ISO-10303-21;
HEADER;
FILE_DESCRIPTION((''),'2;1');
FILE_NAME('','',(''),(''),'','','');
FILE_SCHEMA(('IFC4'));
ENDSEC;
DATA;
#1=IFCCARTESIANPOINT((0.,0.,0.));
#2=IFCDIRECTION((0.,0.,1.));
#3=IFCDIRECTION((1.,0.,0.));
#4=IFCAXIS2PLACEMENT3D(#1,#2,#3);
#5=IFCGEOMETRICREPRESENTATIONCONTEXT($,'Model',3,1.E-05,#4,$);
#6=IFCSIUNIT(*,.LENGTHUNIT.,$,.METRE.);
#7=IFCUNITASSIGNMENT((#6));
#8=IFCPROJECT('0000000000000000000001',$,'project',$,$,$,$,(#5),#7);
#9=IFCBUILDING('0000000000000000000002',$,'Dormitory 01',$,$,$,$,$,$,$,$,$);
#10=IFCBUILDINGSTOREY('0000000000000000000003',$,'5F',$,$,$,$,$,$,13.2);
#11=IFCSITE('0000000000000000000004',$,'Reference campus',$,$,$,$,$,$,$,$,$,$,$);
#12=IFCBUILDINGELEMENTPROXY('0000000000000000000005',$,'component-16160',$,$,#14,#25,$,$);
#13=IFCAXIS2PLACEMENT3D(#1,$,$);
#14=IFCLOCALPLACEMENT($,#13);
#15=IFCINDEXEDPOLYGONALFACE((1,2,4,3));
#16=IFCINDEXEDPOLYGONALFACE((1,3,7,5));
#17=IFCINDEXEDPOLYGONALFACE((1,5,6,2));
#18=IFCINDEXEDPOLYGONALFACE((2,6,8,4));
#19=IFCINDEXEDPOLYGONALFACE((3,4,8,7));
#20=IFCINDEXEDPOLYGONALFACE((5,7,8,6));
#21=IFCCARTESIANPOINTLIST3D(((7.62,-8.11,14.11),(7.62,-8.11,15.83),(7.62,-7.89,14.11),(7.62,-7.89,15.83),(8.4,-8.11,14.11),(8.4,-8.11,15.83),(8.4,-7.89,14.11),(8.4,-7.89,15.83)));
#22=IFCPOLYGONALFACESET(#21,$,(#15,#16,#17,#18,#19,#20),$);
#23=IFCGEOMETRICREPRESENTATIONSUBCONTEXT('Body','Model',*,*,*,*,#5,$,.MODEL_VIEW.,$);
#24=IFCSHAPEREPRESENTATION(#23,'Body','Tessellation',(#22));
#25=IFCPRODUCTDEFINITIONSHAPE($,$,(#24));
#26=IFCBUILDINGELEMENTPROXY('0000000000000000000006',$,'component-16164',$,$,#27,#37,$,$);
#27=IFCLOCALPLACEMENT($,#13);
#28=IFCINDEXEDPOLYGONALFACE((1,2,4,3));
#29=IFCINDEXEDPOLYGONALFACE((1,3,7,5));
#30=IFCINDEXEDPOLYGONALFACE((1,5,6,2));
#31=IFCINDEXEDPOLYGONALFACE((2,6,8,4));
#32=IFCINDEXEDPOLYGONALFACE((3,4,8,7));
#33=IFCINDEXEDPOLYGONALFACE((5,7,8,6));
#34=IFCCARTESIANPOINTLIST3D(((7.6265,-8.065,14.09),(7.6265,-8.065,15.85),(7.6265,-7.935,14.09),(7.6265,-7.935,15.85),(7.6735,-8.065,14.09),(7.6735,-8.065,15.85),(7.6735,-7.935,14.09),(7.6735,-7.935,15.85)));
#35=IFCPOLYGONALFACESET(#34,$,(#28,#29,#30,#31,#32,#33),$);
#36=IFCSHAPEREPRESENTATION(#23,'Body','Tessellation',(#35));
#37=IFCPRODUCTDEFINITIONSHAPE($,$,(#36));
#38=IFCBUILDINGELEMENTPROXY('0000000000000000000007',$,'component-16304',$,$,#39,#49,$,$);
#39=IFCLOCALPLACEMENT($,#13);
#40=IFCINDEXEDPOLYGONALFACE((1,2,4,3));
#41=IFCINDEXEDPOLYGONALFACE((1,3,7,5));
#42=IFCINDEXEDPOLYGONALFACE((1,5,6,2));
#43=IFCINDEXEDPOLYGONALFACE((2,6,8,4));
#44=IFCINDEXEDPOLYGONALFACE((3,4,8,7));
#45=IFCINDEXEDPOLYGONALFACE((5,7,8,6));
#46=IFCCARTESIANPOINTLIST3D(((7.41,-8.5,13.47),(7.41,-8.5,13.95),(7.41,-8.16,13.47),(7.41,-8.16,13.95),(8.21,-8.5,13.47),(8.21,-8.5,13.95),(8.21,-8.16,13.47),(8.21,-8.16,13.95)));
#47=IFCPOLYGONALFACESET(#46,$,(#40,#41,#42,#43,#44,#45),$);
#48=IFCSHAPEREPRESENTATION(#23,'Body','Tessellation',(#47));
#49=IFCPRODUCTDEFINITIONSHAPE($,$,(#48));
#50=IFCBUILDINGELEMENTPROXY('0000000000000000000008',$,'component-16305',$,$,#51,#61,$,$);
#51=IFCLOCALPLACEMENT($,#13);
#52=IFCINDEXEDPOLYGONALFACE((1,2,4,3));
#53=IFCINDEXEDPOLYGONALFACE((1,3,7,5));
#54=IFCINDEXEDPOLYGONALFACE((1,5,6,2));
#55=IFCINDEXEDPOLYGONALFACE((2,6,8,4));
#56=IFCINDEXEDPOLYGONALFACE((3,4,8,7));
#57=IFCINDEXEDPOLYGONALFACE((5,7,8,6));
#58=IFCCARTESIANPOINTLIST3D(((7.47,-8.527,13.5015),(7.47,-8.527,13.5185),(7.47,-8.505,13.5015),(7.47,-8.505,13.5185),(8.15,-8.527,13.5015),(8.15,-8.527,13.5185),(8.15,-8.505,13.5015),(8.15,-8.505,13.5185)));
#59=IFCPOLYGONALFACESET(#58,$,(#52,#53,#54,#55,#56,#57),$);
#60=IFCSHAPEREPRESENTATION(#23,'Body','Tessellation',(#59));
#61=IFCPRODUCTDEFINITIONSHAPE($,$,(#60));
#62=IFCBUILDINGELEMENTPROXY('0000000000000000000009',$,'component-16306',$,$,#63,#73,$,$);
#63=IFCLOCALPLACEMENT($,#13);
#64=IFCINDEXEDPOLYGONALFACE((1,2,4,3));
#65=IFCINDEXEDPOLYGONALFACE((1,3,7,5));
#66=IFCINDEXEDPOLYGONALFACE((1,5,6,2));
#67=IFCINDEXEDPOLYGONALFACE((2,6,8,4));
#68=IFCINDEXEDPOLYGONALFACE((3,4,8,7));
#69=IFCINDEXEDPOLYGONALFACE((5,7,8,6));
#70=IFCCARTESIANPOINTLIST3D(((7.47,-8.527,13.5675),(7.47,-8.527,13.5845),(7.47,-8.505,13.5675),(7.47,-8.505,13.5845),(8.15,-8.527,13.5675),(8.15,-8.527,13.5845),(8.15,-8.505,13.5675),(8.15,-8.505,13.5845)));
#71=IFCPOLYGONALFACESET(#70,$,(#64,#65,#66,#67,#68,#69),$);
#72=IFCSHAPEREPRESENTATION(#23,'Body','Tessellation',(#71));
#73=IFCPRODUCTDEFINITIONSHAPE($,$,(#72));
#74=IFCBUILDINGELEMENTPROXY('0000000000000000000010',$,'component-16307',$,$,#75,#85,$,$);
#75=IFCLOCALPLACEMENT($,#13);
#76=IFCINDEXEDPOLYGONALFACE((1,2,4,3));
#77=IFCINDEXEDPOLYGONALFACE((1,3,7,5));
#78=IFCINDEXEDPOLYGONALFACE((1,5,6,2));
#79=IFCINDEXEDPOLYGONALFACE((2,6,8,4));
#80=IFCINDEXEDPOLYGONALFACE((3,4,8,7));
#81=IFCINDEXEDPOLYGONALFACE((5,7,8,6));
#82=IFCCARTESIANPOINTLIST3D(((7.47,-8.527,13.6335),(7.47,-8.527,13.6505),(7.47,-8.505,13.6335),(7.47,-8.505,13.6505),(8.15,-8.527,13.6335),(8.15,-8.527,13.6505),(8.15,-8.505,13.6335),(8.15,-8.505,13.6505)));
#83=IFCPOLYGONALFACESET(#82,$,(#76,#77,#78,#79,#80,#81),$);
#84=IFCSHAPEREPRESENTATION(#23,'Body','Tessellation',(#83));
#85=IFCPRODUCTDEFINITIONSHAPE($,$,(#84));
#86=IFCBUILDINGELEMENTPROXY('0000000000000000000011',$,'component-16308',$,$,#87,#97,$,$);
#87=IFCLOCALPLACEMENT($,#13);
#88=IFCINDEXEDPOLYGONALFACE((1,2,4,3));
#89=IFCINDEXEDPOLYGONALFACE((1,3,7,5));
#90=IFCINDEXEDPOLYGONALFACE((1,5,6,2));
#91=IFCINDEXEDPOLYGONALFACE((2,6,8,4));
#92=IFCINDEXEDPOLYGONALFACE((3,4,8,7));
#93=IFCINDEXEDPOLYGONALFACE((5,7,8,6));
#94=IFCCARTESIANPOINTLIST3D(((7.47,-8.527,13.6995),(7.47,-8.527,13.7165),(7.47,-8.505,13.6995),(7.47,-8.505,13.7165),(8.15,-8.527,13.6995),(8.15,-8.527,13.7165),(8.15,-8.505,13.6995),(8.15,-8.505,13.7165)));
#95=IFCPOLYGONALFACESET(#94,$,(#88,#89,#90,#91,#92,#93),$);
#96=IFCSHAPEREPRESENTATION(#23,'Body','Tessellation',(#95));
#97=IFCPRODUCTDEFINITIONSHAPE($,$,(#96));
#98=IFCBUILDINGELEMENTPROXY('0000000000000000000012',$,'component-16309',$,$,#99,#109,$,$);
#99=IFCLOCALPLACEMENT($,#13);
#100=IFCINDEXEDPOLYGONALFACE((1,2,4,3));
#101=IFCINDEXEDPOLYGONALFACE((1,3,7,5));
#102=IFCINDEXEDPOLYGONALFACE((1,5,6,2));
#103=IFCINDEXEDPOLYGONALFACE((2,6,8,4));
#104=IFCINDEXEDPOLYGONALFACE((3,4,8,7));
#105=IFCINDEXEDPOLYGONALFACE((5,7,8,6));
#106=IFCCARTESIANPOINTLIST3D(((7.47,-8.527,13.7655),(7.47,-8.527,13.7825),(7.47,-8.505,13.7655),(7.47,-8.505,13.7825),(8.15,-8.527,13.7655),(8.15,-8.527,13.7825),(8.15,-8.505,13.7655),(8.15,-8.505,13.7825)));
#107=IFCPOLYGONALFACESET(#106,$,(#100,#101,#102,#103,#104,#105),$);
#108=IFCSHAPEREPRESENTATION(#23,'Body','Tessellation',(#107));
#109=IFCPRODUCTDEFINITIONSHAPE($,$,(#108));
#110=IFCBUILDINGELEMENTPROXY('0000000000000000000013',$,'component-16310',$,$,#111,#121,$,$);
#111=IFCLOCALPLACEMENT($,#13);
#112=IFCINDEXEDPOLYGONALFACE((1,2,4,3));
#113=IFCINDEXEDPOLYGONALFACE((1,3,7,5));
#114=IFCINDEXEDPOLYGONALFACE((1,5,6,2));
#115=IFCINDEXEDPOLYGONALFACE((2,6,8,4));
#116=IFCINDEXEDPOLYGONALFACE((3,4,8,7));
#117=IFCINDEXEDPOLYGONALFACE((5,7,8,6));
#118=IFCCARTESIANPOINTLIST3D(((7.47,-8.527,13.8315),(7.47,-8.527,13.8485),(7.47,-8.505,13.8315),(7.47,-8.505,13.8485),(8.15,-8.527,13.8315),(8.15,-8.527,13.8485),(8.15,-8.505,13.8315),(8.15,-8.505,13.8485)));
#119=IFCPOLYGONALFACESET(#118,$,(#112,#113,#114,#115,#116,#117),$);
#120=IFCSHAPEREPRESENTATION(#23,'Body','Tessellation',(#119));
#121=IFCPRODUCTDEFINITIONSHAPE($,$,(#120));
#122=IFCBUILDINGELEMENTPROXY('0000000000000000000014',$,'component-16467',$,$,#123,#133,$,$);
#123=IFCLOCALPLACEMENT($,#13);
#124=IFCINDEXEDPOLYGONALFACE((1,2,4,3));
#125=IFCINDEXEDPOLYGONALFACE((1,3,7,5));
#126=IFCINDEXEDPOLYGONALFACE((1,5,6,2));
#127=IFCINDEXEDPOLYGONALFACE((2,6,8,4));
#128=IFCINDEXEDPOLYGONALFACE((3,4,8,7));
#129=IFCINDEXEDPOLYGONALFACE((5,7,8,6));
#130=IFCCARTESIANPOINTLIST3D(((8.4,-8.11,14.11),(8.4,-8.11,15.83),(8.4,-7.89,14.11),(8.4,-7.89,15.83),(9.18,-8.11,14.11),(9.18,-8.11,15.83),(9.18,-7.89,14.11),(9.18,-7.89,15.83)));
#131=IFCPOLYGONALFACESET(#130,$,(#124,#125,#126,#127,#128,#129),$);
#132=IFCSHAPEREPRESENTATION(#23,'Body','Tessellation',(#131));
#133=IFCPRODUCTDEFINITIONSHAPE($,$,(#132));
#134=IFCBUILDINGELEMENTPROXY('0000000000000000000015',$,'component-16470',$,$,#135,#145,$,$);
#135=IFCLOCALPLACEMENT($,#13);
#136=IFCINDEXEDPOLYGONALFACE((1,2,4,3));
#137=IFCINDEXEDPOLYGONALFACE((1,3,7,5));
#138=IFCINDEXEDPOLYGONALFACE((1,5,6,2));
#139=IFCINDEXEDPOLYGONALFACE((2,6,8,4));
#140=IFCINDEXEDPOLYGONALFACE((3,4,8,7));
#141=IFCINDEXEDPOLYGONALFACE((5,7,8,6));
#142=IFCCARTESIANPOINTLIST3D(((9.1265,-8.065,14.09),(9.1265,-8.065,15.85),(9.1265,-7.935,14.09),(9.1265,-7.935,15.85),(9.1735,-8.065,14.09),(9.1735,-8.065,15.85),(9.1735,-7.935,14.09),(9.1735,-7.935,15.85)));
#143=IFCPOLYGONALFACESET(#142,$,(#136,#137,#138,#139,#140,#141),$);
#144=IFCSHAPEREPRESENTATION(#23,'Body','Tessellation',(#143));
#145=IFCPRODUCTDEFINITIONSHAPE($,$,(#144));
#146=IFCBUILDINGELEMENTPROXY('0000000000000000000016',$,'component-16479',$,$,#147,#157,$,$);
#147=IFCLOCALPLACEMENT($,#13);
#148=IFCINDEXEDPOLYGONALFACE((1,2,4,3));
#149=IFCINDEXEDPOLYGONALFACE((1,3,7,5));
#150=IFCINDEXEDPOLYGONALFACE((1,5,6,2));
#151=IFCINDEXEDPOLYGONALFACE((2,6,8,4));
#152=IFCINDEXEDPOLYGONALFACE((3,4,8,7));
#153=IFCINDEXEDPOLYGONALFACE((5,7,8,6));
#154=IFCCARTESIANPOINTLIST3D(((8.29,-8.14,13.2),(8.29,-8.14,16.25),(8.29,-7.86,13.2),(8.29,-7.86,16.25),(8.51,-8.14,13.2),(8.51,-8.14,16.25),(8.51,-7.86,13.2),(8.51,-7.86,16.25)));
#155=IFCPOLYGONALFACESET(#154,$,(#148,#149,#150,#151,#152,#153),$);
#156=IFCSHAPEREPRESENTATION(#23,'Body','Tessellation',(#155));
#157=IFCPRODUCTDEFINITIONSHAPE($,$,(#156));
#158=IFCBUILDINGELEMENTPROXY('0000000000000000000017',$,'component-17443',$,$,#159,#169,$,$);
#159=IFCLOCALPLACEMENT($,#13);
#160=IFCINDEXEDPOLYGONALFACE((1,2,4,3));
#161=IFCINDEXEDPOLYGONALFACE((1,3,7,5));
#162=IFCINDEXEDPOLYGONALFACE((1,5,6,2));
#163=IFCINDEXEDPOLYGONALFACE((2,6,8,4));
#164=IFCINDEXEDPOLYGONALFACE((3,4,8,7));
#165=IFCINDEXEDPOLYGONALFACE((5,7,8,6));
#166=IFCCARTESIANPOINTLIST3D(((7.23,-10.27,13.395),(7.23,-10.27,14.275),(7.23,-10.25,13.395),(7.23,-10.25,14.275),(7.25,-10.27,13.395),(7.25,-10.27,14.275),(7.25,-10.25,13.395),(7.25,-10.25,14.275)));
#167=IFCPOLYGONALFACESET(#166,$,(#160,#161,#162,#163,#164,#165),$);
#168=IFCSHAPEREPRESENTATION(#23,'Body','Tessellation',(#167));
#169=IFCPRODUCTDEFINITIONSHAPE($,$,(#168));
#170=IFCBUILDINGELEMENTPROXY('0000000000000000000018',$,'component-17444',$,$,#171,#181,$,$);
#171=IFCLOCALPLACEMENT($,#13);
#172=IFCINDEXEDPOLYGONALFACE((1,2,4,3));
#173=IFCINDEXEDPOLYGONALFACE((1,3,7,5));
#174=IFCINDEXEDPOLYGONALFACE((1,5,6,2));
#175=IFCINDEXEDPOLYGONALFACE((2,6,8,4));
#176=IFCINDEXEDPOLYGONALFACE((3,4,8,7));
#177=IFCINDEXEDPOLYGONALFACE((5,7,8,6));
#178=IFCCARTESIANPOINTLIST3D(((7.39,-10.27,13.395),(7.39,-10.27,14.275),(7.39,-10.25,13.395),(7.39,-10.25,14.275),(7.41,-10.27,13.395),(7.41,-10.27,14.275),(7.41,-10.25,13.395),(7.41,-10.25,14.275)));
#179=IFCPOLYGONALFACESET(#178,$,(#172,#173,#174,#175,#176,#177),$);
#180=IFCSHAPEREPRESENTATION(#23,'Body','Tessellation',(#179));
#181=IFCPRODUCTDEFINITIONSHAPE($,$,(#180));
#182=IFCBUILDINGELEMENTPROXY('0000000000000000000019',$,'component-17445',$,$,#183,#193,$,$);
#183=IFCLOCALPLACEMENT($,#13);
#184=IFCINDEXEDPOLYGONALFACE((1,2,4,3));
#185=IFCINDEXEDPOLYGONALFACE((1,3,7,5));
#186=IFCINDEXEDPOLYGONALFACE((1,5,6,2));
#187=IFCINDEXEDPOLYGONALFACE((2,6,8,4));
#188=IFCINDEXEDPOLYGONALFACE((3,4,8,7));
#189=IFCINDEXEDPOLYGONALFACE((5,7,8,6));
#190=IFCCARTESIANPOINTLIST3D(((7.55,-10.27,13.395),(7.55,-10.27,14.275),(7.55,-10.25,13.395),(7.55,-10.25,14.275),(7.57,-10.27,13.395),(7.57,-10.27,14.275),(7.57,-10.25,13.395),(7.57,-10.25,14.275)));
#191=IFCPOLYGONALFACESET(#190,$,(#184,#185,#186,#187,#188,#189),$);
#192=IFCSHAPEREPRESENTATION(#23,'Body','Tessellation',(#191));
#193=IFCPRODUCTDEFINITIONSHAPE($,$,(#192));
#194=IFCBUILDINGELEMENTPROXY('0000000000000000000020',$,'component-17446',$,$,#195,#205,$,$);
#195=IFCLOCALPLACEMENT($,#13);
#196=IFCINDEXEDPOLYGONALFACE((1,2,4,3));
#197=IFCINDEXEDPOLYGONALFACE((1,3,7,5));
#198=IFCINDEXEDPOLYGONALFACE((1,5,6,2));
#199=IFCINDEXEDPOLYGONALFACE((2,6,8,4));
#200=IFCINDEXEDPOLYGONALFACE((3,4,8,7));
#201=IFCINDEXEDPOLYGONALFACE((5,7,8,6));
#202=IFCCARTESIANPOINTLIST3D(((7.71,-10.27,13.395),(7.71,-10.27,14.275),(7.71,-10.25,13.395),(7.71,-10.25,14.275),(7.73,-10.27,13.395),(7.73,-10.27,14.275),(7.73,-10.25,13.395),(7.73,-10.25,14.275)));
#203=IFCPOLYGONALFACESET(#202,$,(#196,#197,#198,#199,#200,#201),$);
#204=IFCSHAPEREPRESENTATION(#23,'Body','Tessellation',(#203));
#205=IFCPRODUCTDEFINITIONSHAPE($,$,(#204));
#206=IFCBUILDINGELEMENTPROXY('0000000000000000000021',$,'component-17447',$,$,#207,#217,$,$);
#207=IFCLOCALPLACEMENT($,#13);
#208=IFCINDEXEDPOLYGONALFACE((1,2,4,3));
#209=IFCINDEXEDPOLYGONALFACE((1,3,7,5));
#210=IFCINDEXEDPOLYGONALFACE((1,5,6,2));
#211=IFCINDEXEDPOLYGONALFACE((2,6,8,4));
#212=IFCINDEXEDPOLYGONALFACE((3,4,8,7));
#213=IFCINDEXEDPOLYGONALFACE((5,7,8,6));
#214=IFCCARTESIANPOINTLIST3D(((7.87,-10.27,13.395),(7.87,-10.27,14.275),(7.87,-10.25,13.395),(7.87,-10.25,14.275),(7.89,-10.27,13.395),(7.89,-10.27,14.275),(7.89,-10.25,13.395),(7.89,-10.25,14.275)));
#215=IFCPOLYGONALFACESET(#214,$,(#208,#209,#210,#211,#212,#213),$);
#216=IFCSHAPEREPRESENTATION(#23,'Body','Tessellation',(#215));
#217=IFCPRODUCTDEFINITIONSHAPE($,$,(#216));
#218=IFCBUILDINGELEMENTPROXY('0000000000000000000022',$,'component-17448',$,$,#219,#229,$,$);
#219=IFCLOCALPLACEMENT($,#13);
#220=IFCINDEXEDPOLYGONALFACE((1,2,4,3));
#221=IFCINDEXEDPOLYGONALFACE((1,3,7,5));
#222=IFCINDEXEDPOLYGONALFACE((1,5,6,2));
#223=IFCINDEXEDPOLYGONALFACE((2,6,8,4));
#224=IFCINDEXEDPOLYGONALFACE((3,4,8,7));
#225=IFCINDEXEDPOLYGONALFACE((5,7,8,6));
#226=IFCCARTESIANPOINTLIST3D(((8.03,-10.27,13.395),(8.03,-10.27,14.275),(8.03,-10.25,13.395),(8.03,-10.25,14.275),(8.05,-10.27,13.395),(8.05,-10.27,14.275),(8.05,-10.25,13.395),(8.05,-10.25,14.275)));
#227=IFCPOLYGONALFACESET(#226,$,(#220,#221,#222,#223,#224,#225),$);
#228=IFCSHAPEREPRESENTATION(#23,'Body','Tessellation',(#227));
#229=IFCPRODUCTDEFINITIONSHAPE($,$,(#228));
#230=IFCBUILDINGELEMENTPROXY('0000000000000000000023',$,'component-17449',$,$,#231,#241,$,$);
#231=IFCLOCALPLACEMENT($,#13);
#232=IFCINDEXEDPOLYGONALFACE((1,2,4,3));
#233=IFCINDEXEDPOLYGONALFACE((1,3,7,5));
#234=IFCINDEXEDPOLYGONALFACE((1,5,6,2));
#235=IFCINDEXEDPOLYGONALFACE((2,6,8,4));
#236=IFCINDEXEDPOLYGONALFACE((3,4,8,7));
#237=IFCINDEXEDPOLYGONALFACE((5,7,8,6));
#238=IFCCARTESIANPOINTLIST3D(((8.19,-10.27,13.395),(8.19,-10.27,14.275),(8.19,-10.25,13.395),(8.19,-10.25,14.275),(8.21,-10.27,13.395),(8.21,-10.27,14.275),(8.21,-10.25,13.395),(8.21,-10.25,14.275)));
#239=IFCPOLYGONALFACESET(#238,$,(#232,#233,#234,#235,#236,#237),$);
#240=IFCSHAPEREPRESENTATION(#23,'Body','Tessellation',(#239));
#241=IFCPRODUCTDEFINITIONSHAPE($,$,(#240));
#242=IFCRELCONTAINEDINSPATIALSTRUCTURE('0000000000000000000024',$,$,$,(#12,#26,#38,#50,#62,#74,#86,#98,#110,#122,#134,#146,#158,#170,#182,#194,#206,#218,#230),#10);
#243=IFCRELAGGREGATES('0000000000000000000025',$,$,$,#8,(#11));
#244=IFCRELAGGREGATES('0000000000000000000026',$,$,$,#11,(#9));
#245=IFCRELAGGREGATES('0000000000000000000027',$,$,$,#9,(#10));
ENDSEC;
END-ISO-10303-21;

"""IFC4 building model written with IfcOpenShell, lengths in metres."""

from ifc_helpers import new_model, si_unit, frame, origin, origin_with_axes, origin_2d, place, context, subcontext, project, spatial, rectangle, extrude, element, save


model = new_model("IFC4")

# Units and contexts
model_context = context("Model", 3, precision=1e-05, world=origin_with_axes())
body_context = subcontext(model_context, "Body", "Model", "MODEL_VIEW")
ifc_project = project(units=[si_unit("LENGTHUNIT", "METRE")], contexts=[model_context])

# Site, building, storey
site = spatial("IfcSite", under=ifc_project, Name="Reference campus")
building = spatial("IfcBuilding", under=site, Name="Dormitory 01")
storey = spatial("IfcBuildingStorey", under=building, Name="5F", Elevation=13.2)

# Building element proxies
proxy_1_placement = place(None, frame((8.01, -8.0, 14.11), z_axis=(0.0, 0.0, 1.0), x_axis=(1.0, 0.0, 0.0)))
element("IfcBuildingElementProxy", 1, at=proxy_1_placement, inside=storey, Name="component-16160", context=body_context, shape_type="SweptSolid", body=[
    extrude(rectangle(XDim=0.78, YDim=0.22, at=origin_2d()), origin(), (0.0, 0.0, 1.0), 1.72),
])
proxy_2_placement = place(None, frame((7.65, -8.0, 14.09), z_axis=(0.0, 0.0, 1.0), x_axis=(1.0, 0.0, 0.0)))
element("IfcBuildingElementProxy", 2, at=proxy_2_placement, inside=storey, Name="component-16164", context=body_context, shape_type="SweptSolid", body=[
    extrude(rectangle(XDim=0.047, YDim=0.13, at=origin_2d()), origin(), (0.0, 0.0, 1.0), 1.76),
])
proxy_3_placement = place(None, frame((7.81, -8.33, 13.47), z_axis=(0.0, 0.0, 1.0), x_axis=(1.0, 0.0, 0.0)))
element("IfcBuildingElementProxy", 3, at=proxy_3_placement, inside=storey, Name="component-16304", context=body_context, shape_type="SweptSolid", body=[
    extrude(rectangle(XDim=0.8, YDim=0.34, at=origin_2d()), origin(), (0.0, 0.0, 1.0), 0.48),
])
for number, where, z_axis, x_axis, name in (
    (4, (7.81, -8.516, 13.5015), (0.0, 0.0, 1.0), (1.0, 0.0, 0.0), "component-16305"),
    (5, (7.81, -8.516, 13.5675), (0.0, 0.0, 1.0), (1.0, 0.0, 0.0), "component-16306"),
    (6, (7.81, -8.516, 13.6335), (0.0, 0.0, 1.0), (1.0, 0.0, 0.0), "component-16307"),
    (7, (7.81, -8.516, 13.6995), (0.0, 0.0, 1.0), (1.0, 0.0, 0.0), "component-16308"),
    (8, (7.81, -8.516, 13.7655), (0.0, 0.0, 1.0), (1.0, 0.0, 0.0), "component-16309"),
    (9, (7.81, -8.516, 13.8315), (0.0, 0.0, 1.0), (1.0, 0.0, 0.0), "component-16310"),
):
    element("IfcBuildingElementProxy", number, at=place(None, frame(where, z_axis=z_axis, x_axis=x_axis)), inside=storey, Name=name, context=body_context, shape_type="SweptSolid", body=[
        extrude(rectangle(XDim=0.68, YDim=0.022, at=origin_2d()), origin(), (0.0, 0.0, 1.0), 0.017),
    ])
proxy_4_placement = place(None, frame((8.79, -8.0, 14.11), z_axis=(0.0, 0.0, 1.0), x_axis=(1.0, 0.0, 0.0)))
element("IfcBuildingElementProxy", 10, at=proxy_4_placement, inside=storey, Name="component-16467", context=body_context, shape_type="SweptSolid", body=[
    extrude(rectangle(XDim=0.78, YDim=0.22, at=origin_2d()), origin(), (0.0, 0.0, 1.0), 1.72),
])
proxy_5_placement = place(None, frame((9.15, -8.0, 14.09), z_axis=(0.0, 0.0, 1.0), x_axis=(1.0, 0.0, 0.0)))
element("IfcBuildingElementProxy", 11, at=proxy_5_placement, inside=storey, Name="component-16470", context=body_context, shape_type="SweptSolid", body=[
    extrude(rectangle(XDim=0.047, YDim=0.13, at=origin_2d()), origin(), (0.0, 0.0, 1.0), 1.76),
])
proxy_6_placement = place(None, frame((8.4, -8.0, 13.2), z_axis=(0.0, 0.0, 1.0), x_axis=(1.0, 0.0, 0.0)))
element("IfcBuildingElementProxy", 12, at=proxy_6_placement, inside=storey, Name="component-16479", context=body_context, shape_type="SweptSolid", body=[
    extrude(rectangle(XDim=0.22, YDim=0.28, at=origin_2d()), origin(), (0.0, 0.0, 1.0), 3.05),
])
for number, where, z_axis, x_axis, name in (
    (13, (7.24, -10.26, 13.395), (0.0, 0.0, 1.0), (1.0, 0.0, 0.0), "component-17443"),
    (14, (7.4, -10.26, 13.395), (0.0, 0.0, 1.0), (1.0, 0.0, 0.0), "component-17444"),
    (15, (7.56, -10.26, 13.395), (0.0, 0.0, 1.0), (1.0, 0.0, 0.0), "component-17445"),
    (16, (7.72, -10.26, 13.395), (0.0, 0.0, 1.0), (1.0, 0.0, 0.0), "component-17446"),
    (17, (7.88, -10.26, 13.395), (0.0, 0.0, 1.0), (1.0, 0.0, 0.0), "component-17447"),
    (18, (8.04, -10.26, 13.395), (0.0, 0.0, 1.0), (1.0, 0.0, 0.0), "component-17448"),
    (19, (8.2, -10.26, 13.395), (0.0, 0.0, 1.0), (1.0, 0.0, 0.0), "component-17449"),
):
    element("IfcBuildingElementProxy", number, at=place(None, frame(where, z_axis=z_axis, x_axis=x_axis)), inside=storey, Name=name, context=body_context, shape_type="SweptSolid", body=[
        extrude(rectangle(XDim=0.02, YDim=0.02, at=origin_2d()), origin(), (0.0, 0.0, 1.0), 0.88),
    ])

save(model, "model.ifc")
